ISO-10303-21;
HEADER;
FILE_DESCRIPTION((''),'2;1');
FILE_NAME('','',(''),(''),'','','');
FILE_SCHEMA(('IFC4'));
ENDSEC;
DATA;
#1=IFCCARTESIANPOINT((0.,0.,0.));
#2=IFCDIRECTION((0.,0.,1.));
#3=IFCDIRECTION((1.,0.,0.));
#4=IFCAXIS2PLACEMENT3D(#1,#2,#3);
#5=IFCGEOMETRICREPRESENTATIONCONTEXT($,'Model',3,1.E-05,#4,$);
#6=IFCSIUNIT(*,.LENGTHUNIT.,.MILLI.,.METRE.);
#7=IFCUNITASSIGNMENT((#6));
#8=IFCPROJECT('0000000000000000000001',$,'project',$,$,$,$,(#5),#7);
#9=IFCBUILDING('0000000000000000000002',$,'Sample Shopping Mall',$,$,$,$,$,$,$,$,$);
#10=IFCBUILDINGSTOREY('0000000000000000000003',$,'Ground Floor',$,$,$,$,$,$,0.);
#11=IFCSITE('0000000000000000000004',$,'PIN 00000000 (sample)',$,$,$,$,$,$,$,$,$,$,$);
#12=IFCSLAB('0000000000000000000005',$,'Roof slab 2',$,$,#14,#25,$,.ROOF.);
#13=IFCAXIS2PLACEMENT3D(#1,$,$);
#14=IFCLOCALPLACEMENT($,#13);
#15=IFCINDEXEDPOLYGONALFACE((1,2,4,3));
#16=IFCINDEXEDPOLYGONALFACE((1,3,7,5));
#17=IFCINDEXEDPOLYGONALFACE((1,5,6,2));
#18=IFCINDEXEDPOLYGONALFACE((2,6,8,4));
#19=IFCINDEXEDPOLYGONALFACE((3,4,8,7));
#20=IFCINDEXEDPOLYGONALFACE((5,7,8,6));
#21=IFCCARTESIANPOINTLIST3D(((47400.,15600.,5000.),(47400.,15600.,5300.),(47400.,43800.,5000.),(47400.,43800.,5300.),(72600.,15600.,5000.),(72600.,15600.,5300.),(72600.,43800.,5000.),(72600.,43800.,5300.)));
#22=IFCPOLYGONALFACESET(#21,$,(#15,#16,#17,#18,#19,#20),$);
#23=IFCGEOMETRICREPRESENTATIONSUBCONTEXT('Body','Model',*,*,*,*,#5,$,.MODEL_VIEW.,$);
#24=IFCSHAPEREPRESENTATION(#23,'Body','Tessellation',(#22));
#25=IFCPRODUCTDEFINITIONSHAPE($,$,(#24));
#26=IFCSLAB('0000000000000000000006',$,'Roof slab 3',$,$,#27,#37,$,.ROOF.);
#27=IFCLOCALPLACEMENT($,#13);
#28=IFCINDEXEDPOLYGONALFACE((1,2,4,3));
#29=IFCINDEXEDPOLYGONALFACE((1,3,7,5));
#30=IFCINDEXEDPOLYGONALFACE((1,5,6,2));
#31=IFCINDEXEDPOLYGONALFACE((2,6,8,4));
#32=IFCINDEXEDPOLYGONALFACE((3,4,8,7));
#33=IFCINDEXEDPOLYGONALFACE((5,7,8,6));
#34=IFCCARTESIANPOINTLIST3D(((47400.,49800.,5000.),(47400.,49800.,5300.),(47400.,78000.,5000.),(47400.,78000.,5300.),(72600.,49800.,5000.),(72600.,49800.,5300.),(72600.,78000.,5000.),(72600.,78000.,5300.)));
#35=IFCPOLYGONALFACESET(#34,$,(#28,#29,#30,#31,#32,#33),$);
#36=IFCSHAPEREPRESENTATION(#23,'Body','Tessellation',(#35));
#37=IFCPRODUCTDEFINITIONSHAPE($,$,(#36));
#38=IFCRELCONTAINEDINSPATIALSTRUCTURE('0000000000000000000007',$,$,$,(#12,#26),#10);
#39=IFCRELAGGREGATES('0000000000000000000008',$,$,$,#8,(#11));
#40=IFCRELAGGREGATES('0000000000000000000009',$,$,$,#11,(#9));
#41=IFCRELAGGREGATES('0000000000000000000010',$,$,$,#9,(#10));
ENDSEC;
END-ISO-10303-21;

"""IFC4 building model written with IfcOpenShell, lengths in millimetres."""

from ifc_helpers import new_model, si_unit, frame, origin_with_axes, place, context, subcontext, project, spatial, indexed_curve, outline, extrude, element, save


model = new_model("IFC4")

# Units and contexts
model_context = context("Model", 3, precision=1e-05, world=origin_with_axes())
body_context = subcontext(model_context, "Body", "Model", "MODEL_VIEW")
ifc_project = project(units=[si_unit("LENGTHUNIT", "METRE", prefix="MILLI")], contexts=[model_context])

# Site, building, storey
site = spatial("IfcSite", under=ifc_project, Name="PIN 00000000 (sample)")
building = spatial("IfcBuilding", under=site, Name="Sample Shopping Mall")
storey = spatial("IfcBuildingStorey", under=building, Name="Ground Floor", Elevation=0.0)

# Slabs
slab_1_placement = place(None, frame((0.0, 0.0, 5000.0), z_axis=(0.0, 0.0, 1.0), x_axis=(1.0, 0.0, 0.0)))
element("IfcSlab", 1, at=slab_1_placement, inside=storey, Name="Roof slab 2", PredefinedType="ROOF", context=body_context, shape_type="SweptSolid", body=[
    extrude(outline(indexed_curve([(47400.0, 15600.0), (72600.0, 15600.0), (72600.0, 43800.0), (47400.0, 43800.0)])), None, (0.0, 0.0, 1.0), 300.0),
])
slab_2_placement = place(None, frame((0.0, 0.0, 5000.0), z_axis=(0.0, 0.0, 1.0), x_axis=(1.0, 0.0, 0.0)))
element("IfcSlab", 2, at=slab_2_placement, inside=storey, Name="Roof slab 3", PredefinedType="ROOF", context=body_context, shape_type="SweptSolid", body=[
    extrude(outline(indexed_curve([(47400.0, 49800.0), (72600.0, 49800.0), (72600.0, 78000.0), (47400.0, 78000.0)])), None, (0.0, 0.0, 1.0), 300.0),
])

save(model, "model.ifc")
